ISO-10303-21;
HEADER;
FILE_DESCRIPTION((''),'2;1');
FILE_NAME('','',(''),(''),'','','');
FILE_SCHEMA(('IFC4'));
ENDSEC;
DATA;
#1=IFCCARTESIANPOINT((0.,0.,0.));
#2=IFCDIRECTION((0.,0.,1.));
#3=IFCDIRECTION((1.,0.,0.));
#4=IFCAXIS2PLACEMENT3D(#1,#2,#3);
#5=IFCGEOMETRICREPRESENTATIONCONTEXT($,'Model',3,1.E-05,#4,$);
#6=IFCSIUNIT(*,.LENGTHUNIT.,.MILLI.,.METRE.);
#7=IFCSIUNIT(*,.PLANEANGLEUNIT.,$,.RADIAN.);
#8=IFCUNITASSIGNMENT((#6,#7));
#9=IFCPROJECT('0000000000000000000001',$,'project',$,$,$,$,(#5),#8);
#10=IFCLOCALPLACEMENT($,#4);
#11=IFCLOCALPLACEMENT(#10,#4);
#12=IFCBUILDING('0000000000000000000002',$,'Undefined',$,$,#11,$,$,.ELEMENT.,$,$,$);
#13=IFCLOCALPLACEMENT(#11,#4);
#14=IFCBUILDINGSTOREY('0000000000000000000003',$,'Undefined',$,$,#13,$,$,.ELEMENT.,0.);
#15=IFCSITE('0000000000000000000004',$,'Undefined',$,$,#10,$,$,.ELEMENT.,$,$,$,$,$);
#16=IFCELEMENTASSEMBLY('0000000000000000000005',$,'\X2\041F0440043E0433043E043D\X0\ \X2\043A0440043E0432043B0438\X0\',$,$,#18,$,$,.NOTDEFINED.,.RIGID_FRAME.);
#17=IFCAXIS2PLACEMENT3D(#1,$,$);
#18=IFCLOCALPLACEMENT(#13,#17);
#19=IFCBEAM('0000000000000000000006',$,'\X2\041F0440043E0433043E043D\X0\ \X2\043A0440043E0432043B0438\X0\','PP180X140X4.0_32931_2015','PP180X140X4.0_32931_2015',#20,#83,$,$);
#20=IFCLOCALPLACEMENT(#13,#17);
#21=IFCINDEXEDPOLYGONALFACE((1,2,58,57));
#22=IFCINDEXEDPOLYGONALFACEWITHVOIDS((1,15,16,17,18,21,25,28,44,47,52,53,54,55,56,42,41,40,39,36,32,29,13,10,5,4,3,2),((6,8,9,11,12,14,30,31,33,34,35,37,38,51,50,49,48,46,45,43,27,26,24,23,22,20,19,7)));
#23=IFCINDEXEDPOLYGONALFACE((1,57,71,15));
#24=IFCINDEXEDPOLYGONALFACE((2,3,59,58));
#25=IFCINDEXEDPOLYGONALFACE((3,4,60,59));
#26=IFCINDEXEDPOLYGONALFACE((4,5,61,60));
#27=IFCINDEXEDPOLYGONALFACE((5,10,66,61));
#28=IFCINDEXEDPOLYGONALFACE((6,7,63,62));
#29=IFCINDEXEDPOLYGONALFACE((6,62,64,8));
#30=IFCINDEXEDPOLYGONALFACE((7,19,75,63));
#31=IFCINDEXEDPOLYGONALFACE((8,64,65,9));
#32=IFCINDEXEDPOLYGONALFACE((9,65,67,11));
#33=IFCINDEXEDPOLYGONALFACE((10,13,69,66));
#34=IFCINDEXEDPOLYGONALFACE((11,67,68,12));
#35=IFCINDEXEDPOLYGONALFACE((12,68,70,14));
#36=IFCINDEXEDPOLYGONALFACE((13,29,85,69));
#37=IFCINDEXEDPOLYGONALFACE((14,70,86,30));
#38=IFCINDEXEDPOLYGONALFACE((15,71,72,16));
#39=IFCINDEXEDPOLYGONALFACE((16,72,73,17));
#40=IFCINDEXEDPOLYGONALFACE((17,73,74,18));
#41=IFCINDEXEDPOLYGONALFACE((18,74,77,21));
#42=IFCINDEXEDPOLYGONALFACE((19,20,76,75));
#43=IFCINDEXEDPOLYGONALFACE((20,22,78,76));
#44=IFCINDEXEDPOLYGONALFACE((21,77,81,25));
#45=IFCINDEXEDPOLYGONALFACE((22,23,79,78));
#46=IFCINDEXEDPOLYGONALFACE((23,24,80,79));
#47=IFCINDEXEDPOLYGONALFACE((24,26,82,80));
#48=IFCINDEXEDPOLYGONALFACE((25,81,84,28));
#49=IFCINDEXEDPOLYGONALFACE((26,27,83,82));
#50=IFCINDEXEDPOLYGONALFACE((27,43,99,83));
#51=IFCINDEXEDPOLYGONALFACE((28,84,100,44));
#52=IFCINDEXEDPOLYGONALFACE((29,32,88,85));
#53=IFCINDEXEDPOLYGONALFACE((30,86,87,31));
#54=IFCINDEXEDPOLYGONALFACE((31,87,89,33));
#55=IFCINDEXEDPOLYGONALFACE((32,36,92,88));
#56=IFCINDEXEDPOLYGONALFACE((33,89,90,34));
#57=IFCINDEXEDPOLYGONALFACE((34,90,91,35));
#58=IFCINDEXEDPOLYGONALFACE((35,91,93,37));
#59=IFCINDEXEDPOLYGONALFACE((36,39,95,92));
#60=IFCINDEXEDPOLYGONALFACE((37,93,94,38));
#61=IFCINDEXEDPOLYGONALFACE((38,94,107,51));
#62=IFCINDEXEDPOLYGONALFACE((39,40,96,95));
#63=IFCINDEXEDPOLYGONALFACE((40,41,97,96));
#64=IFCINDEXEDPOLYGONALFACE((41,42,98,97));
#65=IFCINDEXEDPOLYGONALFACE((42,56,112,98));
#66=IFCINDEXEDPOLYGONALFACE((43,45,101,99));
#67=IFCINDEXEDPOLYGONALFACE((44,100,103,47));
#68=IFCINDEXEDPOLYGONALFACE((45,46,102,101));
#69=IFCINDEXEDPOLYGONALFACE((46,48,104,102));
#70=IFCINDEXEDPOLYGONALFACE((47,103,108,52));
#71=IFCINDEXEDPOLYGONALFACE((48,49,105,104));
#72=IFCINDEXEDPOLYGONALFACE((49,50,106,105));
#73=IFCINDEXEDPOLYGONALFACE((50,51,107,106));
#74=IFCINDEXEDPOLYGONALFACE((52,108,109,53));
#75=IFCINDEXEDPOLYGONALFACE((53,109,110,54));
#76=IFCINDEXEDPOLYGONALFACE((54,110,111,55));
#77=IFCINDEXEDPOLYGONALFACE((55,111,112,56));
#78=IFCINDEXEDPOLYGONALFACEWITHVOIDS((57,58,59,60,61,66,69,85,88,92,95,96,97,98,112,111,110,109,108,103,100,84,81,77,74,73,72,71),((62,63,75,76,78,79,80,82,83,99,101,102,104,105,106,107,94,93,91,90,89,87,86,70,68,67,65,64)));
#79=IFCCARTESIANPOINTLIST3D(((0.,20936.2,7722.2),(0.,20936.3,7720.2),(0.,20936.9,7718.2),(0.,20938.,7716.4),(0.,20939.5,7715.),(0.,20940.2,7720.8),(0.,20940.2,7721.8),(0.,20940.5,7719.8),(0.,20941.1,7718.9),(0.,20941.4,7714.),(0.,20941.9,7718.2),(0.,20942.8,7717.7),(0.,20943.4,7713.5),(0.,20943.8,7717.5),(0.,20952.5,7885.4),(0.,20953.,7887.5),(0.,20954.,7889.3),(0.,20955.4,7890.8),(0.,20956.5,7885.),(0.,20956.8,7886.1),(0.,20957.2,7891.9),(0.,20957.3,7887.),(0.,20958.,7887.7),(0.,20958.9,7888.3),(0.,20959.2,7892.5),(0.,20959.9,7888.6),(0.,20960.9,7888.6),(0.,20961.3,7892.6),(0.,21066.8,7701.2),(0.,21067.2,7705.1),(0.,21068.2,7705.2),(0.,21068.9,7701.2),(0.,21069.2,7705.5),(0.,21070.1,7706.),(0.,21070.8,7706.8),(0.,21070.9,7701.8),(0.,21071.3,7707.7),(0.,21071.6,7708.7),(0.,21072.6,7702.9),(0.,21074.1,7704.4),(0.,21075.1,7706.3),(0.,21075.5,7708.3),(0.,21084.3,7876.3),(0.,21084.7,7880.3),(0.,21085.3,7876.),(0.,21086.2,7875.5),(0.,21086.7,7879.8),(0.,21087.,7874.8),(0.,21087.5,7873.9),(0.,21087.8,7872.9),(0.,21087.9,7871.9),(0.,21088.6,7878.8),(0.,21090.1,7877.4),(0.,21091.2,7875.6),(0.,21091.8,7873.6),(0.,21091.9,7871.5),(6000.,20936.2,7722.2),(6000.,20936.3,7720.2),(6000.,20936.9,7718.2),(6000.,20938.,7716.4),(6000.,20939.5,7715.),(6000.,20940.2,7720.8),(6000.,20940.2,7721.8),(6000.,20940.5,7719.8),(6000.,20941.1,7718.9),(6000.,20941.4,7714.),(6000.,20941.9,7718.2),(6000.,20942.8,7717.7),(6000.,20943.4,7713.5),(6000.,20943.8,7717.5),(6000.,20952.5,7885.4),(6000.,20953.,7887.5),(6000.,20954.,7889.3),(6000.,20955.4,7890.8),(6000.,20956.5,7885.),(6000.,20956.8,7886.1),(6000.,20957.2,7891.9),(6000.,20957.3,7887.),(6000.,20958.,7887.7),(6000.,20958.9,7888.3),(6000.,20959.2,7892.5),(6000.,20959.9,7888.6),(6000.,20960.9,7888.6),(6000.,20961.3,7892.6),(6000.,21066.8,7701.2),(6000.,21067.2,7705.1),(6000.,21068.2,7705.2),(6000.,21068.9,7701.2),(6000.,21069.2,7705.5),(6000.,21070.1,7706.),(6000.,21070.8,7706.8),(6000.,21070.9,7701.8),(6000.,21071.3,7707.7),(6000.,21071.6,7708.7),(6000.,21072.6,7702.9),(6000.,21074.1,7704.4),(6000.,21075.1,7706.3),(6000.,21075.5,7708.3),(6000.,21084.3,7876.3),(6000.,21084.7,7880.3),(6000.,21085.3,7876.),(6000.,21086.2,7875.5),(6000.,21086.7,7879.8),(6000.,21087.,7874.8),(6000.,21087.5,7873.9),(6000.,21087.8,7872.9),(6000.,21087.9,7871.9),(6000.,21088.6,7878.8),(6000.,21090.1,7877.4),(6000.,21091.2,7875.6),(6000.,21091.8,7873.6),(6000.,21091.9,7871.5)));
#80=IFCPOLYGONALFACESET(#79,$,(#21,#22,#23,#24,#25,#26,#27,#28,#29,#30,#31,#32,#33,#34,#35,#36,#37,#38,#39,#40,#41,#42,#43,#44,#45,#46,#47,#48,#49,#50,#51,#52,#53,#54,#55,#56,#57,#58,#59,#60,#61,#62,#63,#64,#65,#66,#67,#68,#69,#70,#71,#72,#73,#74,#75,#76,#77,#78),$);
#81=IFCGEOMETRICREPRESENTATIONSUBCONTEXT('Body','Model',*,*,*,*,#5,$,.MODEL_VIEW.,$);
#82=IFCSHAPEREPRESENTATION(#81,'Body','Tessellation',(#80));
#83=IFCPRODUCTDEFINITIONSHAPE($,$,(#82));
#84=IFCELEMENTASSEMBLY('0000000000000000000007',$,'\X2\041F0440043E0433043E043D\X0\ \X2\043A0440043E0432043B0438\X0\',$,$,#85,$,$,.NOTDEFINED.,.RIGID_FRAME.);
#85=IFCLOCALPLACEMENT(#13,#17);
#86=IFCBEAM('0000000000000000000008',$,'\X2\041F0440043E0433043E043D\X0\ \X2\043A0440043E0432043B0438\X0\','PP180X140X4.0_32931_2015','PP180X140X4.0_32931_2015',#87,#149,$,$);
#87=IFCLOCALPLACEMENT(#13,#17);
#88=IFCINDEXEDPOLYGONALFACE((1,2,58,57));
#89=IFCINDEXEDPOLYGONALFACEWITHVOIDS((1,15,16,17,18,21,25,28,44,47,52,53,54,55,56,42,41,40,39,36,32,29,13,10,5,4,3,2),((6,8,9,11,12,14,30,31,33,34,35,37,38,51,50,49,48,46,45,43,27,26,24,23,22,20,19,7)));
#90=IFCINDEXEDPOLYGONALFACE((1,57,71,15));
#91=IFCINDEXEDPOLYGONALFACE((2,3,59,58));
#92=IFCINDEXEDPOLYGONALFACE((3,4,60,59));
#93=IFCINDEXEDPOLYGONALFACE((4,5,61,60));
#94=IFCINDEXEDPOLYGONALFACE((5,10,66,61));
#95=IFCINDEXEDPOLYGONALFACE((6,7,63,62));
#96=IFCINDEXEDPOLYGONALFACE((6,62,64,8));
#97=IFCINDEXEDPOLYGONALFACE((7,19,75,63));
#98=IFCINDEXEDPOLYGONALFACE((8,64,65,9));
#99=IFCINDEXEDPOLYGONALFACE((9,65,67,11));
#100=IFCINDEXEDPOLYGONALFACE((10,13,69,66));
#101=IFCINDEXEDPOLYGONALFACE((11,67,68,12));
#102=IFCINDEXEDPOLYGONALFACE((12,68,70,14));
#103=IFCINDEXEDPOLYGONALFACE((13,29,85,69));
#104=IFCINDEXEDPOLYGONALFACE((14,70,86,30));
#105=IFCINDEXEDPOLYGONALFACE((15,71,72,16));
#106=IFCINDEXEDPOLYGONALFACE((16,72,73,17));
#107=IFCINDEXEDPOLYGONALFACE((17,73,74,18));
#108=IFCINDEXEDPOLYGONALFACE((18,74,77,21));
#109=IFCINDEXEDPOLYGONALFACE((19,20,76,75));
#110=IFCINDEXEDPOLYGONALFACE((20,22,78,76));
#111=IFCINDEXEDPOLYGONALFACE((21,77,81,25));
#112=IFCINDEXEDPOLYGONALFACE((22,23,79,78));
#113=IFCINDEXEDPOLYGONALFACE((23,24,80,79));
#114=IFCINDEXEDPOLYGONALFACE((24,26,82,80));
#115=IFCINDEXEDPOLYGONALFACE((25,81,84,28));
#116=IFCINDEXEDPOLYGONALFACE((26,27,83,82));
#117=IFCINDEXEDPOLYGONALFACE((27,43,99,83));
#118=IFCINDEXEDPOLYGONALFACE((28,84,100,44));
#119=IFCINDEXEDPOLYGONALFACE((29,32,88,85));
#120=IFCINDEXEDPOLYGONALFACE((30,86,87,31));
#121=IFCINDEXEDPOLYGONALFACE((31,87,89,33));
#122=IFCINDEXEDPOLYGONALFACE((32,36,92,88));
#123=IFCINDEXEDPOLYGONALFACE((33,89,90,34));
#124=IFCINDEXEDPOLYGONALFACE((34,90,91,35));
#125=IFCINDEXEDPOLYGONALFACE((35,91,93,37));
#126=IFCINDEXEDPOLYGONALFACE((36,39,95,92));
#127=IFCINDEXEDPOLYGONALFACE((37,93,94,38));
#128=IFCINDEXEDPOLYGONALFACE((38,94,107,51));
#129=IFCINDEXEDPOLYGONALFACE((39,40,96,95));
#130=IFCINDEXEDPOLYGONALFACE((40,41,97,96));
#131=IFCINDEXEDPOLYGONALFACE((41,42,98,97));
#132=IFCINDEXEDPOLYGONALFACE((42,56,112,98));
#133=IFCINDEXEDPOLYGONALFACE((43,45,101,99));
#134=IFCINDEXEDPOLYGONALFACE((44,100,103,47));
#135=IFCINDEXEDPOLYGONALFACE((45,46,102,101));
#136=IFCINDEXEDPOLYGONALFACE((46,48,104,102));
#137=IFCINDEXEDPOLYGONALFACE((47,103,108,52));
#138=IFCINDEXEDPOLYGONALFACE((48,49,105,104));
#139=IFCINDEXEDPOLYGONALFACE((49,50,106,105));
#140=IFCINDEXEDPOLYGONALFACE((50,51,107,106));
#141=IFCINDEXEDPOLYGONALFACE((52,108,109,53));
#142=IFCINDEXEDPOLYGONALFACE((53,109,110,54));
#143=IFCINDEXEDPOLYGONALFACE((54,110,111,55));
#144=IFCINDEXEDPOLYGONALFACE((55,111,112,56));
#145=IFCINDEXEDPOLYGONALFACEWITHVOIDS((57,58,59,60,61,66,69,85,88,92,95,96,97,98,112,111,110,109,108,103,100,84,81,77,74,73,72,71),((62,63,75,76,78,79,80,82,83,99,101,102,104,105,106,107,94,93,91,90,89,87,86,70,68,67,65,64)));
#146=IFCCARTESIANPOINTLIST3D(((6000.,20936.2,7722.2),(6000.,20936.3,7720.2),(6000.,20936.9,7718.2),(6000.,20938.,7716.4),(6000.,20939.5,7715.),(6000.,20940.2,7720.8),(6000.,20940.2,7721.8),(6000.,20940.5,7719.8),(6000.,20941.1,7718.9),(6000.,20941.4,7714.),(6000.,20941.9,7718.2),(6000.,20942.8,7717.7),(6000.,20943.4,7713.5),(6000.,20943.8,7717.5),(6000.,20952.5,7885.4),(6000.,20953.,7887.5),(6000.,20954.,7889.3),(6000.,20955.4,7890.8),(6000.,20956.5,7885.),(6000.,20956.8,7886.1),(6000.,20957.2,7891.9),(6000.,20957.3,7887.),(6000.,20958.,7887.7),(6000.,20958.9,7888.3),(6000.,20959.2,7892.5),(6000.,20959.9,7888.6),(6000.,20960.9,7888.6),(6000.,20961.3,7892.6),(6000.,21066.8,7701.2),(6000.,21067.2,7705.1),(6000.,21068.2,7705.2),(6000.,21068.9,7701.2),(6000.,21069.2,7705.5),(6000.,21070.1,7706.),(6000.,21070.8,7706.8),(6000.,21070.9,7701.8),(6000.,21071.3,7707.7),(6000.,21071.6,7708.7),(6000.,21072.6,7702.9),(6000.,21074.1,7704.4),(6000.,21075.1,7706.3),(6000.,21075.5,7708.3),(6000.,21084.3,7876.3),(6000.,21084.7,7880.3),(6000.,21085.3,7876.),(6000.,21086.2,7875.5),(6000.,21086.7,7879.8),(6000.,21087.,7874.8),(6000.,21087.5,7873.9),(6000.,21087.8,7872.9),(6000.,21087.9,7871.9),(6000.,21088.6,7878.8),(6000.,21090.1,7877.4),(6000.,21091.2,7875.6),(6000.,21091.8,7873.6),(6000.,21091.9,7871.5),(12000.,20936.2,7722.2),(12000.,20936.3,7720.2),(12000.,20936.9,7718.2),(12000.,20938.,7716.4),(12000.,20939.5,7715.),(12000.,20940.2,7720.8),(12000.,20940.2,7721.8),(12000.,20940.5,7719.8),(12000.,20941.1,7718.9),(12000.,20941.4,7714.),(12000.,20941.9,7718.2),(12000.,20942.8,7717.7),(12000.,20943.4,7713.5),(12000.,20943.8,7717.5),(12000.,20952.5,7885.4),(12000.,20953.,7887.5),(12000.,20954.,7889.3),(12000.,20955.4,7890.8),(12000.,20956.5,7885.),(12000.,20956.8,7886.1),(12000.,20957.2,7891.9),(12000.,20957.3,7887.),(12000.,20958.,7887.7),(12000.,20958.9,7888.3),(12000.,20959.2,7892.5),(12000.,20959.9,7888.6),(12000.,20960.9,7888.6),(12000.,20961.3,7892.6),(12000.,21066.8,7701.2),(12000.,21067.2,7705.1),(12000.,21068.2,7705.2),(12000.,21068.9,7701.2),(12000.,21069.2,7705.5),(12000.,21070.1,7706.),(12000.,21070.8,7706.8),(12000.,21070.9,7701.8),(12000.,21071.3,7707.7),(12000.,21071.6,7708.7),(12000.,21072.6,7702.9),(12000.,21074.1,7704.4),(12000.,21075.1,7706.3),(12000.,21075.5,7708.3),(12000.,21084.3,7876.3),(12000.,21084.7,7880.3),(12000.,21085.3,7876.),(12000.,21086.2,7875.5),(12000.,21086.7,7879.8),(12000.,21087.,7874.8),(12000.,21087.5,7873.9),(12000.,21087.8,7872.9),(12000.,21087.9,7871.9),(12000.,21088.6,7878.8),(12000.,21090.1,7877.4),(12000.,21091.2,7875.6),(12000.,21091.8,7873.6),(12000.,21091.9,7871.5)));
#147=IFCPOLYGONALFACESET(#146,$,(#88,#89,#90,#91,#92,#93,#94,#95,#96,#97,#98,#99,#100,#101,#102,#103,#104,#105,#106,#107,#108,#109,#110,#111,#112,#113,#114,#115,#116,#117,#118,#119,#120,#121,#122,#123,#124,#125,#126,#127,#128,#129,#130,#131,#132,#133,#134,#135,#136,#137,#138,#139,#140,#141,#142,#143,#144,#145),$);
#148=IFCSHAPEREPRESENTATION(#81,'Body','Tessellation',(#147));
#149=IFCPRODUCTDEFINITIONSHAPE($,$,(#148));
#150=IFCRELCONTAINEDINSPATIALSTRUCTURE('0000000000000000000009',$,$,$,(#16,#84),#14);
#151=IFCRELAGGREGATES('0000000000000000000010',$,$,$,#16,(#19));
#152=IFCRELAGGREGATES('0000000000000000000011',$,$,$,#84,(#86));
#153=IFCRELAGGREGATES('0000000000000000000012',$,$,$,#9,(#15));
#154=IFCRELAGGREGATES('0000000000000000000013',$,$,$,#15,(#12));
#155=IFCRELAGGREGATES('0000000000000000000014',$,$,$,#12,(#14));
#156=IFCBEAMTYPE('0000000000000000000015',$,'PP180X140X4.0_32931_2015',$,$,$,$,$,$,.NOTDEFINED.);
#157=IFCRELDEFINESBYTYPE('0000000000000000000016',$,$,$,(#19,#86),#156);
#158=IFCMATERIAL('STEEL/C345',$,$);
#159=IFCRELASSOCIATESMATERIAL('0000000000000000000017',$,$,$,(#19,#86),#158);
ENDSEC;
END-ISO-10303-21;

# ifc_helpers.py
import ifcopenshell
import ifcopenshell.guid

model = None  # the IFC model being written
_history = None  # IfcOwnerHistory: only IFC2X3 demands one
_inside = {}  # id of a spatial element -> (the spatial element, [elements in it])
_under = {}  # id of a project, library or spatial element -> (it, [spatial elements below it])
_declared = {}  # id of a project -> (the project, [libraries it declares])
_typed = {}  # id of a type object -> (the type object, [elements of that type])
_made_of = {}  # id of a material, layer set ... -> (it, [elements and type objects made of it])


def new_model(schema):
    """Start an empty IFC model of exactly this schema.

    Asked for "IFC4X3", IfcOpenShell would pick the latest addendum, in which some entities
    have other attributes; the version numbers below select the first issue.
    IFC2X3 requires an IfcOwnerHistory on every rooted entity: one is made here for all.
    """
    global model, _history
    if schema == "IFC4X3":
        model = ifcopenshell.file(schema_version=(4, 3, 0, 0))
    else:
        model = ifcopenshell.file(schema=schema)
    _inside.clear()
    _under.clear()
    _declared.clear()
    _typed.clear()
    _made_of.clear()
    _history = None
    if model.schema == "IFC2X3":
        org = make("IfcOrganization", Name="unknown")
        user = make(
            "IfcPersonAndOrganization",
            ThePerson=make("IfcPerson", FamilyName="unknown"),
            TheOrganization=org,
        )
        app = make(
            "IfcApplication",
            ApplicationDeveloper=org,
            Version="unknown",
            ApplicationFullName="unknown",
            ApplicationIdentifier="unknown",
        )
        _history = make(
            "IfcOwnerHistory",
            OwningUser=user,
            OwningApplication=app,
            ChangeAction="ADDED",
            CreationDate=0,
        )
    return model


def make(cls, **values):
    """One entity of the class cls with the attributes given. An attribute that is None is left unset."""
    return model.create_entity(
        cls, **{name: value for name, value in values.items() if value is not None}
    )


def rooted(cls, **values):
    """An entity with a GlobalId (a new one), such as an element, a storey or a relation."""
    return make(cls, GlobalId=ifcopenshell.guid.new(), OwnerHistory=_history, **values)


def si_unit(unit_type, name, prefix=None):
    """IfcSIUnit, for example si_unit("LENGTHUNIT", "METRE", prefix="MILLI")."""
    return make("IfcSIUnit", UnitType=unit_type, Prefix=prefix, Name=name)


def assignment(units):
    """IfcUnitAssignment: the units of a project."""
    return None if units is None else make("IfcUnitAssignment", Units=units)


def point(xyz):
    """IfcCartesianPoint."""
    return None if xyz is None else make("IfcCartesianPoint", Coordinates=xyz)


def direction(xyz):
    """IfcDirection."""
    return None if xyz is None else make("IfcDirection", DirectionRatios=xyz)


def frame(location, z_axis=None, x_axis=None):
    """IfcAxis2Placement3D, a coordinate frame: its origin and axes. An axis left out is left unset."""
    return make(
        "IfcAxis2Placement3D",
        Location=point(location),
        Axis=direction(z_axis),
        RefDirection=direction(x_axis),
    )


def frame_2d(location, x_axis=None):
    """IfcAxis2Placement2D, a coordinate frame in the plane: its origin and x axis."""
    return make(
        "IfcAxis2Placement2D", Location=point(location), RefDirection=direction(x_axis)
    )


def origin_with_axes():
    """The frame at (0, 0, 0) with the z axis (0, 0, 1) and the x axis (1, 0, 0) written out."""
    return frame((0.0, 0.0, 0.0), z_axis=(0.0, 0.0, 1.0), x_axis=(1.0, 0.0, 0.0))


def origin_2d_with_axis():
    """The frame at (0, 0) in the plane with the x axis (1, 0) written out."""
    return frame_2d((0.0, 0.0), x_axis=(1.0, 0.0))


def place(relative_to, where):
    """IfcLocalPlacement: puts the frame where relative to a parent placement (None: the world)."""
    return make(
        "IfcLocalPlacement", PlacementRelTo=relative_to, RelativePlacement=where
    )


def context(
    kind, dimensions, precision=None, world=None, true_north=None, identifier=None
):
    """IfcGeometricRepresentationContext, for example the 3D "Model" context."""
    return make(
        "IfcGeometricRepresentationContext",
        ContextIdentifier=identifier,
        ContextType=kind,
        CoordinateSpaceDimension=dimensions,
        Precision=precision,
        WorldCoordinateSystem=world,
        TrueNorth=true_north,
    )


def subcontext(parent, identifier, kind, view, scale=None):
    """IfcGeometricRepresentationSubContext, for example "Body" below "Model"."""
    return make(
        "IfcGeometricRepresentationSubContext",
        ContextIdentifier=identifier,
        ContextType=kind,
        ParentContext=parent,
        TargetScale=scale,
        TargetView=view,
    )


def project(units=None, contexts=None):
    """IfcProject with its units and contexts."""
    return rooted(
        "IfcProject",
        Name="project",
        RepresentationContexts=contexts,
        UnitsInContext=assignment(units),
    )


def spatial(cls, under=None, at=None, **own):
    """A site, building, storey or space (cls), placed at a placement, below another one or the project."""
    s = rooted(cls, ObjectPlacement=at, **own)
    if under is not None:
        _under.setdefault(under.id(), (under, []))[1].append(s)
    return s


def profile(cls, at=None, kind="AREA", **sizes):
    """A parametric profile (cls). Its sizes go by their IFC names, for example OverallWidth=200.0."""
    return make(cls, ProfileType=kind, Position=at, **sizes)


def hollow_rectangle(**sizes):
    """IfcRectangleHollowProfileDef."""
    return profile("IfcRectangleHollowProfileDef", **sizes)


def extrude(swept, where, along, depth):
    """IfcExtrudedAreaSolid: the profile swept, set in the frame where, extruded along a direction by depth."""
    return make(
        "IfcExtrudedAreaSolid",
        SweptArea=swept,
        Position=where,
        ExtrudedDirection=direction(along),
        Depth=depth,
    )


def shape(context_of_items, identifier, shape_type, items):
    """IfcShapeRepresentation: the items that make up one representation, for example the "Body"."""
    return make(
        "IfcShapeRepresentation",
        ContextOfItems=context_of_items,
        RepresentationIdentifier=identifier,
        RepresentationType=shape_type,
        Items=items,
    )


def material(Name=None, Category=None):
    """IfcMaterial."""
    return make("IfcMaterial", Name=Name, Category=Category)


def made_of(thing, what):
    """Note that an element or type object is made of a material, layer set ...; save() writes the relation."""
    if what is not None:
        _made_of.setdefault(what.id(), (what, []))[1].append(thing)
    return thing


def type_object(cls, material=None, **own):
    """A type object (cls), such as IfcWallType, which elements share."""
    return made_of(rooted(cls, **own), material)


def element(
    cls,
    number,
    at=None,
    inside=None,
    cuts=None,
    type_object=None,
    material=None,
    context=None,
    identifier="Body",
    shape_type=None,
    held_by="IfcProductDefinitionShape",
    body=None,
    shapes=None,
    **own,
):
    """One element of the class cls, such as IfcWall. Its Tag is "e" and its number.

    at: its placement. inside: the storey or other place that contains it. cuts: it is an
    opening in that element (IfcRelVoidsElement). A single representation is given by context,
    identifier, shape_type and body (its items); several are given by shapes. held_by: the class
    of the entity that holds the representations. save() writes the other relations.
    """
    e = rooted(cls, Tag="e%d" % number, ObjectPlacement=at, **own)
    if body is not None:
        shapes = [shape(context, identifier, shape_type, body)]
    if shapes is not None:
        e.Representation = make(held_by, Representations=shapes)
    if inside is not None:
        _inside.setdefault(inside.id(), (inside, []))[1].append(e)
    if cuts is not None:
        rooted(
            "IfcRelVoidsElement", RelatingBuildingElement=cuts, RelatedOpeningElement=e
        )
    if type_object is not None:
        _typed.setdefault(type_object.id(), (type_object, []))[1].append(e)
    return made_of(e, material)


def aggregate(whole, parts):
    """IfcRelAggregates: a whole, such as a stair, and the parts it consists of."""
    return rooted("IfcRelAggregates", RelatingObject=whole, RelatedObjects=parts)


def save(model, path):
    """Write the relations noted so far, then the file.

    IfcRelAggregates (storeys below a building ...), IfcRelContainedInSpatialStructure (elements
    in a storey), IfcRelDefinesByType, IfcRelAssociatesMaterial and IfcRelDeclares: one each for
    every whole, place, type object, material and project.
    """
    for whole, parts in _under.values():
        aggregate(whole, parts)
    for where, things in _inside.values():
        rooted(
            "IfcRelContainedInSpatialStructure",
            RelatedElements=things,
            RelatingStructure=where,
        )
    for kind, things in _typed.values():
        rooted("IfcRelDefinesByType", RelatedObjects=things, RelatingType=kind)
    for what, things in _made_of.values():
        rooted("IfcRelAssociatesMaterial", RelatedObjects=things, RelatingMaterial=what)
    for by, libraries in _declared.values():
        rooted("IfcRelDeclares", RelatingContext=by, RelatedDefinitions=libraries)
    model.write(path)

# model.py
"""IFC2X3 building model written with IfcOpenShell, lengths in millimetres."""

from ifc_helpers import new_model, si_unit, frame, origin_with_axes, origin_2d_with_axis, place, context, subcontext, project, spatial, hollow_rectangle, extrude, material, type_object, element, aggregate, save


model = new_model("IFC2X3")

# Units and contexts
model_context = context("Model", 3, precision=1e-05, world=origin_with_axes())
body_context = subcontext(model_context, "Body", "Model", "MODEL_VIEW")
ifc_project = project(units=[si_unit("LENGTHUNIT", "METRE", prefix="MILLI"), si_unit("PLANEANGLEUNIT", "RADIAN")], contexts=[model_context])

# Site, building, storey
site_placement = place(None, origin_with_axes())
site = spatial("IfcSite", under=ifc_project, at=site_placement, Name="Undefined", CompositionType="ELEMENT")
building_placement = place(site_placement, origin_with_axes())
building = spatial("IfcBuilding", under=site, at=building_placement, Name="Undefined", CompositionType="ELEMENT")
storey_placement = place(building_placement, origin_with_axes())
storey = spatial("IfcBuildingStorey", under=building, at=storey_placement, Name="Undefined", CompositionType="ELEMENT", Elevation=0.0)

# Shared definitions
ifc_material_1 = material(Name="STEEL/C345")

# Element assemblies, beams
assembly_1_placement = place(storey_placement, origin_with_axes())
assembly_1 = element("IfcElementAssembly", 1, at=assembly_1_placement, inside=storey, Name="Прогон кровли", AssemblyPlace="NOTDEFINED", PredefinedType="RIGID_FRAME")
beam_type_1 = type_object("IfcBeamType", Name="PP180X140X4.0_32931_2015", PredefinedType="NOTDEFINED")
beam_1_placement = place(assembly_1_placement, frame((0.0, 21014.0, 7796.9), z_axis=(0.0, 0.099504, 0.995037), x_axis=(1.0, 0.0, 0.0)))
beam_1 = element("IfcBeam", 2, at=beam_1_placement, type_object=beam_type_1, material=ifc_material_1, Name="Прогон кровли", Description="PP180X140X4.0_32931_2015", ObjectType="PP180X140X4.0_32931_2015", context=body_context, shape_type="SweptSolid", body=[
    extrude(hollow_rectangle(XDim=140.0, YDim=180.0, WallThickness=4.0, InnerFilletRadius=4.0, OuterFilletRadius=8.0, at=origin_2d_with_axis()), frame((6000.0, 0.0, 0.0), z_axis=(-1.0, 0.0, 0.0), x_axis=(0.0, -1.0, 0.0)), (0.0, 0.0, 1.0), 6000.0),
])
aggregate(assembly_1, [beam_1])
assembly_2_placement = place(storey_placement, origin_with_axes())
assembly_2 = element("IfcElementAssembly", 3, at=assembly_2_placement, inside=storey, Name="Прогон кровли", AssemblyPlace="NOTDEFINED", PredefinedType="RIGID_FRAME")
beam_2_placement = place(assembly_2_placement, frame((6000.0, 21014.0, 7796.9), z_axis=(0.0, 0.099504, 0.995037), x_axis=(1.0, 0.0, 0.0)))
beam_2 = element("IfcBeam", 4, at=beam_2_placement, type_object=beam_type_1, material=ifc_material_1, Name="Прогон кровли", Description="PP180X140X4.0_32931_2015", ObjectType="PP180X140X4.0_32931_2015", context=body_context, shape_type="SweptSolid", body=[
    extrude(hollow_rectangle(XDim=140.0, YDim=180.0, WallThickness=4.0, InnerFilletRadius=4.0, OuterFilletRadius=8.0, at=origin_2d_with_axis()), frame((6000.0, 0.0, 0.0), z_axis=(-1.0, 0.0, 0.0), x_axis=(0.0, -1.0, 0.0)), (0.0, 0.0, 1.0), 6000.0),
])
aggregate(assembly_2, [beam_2])

save(model, "model.ifc")
